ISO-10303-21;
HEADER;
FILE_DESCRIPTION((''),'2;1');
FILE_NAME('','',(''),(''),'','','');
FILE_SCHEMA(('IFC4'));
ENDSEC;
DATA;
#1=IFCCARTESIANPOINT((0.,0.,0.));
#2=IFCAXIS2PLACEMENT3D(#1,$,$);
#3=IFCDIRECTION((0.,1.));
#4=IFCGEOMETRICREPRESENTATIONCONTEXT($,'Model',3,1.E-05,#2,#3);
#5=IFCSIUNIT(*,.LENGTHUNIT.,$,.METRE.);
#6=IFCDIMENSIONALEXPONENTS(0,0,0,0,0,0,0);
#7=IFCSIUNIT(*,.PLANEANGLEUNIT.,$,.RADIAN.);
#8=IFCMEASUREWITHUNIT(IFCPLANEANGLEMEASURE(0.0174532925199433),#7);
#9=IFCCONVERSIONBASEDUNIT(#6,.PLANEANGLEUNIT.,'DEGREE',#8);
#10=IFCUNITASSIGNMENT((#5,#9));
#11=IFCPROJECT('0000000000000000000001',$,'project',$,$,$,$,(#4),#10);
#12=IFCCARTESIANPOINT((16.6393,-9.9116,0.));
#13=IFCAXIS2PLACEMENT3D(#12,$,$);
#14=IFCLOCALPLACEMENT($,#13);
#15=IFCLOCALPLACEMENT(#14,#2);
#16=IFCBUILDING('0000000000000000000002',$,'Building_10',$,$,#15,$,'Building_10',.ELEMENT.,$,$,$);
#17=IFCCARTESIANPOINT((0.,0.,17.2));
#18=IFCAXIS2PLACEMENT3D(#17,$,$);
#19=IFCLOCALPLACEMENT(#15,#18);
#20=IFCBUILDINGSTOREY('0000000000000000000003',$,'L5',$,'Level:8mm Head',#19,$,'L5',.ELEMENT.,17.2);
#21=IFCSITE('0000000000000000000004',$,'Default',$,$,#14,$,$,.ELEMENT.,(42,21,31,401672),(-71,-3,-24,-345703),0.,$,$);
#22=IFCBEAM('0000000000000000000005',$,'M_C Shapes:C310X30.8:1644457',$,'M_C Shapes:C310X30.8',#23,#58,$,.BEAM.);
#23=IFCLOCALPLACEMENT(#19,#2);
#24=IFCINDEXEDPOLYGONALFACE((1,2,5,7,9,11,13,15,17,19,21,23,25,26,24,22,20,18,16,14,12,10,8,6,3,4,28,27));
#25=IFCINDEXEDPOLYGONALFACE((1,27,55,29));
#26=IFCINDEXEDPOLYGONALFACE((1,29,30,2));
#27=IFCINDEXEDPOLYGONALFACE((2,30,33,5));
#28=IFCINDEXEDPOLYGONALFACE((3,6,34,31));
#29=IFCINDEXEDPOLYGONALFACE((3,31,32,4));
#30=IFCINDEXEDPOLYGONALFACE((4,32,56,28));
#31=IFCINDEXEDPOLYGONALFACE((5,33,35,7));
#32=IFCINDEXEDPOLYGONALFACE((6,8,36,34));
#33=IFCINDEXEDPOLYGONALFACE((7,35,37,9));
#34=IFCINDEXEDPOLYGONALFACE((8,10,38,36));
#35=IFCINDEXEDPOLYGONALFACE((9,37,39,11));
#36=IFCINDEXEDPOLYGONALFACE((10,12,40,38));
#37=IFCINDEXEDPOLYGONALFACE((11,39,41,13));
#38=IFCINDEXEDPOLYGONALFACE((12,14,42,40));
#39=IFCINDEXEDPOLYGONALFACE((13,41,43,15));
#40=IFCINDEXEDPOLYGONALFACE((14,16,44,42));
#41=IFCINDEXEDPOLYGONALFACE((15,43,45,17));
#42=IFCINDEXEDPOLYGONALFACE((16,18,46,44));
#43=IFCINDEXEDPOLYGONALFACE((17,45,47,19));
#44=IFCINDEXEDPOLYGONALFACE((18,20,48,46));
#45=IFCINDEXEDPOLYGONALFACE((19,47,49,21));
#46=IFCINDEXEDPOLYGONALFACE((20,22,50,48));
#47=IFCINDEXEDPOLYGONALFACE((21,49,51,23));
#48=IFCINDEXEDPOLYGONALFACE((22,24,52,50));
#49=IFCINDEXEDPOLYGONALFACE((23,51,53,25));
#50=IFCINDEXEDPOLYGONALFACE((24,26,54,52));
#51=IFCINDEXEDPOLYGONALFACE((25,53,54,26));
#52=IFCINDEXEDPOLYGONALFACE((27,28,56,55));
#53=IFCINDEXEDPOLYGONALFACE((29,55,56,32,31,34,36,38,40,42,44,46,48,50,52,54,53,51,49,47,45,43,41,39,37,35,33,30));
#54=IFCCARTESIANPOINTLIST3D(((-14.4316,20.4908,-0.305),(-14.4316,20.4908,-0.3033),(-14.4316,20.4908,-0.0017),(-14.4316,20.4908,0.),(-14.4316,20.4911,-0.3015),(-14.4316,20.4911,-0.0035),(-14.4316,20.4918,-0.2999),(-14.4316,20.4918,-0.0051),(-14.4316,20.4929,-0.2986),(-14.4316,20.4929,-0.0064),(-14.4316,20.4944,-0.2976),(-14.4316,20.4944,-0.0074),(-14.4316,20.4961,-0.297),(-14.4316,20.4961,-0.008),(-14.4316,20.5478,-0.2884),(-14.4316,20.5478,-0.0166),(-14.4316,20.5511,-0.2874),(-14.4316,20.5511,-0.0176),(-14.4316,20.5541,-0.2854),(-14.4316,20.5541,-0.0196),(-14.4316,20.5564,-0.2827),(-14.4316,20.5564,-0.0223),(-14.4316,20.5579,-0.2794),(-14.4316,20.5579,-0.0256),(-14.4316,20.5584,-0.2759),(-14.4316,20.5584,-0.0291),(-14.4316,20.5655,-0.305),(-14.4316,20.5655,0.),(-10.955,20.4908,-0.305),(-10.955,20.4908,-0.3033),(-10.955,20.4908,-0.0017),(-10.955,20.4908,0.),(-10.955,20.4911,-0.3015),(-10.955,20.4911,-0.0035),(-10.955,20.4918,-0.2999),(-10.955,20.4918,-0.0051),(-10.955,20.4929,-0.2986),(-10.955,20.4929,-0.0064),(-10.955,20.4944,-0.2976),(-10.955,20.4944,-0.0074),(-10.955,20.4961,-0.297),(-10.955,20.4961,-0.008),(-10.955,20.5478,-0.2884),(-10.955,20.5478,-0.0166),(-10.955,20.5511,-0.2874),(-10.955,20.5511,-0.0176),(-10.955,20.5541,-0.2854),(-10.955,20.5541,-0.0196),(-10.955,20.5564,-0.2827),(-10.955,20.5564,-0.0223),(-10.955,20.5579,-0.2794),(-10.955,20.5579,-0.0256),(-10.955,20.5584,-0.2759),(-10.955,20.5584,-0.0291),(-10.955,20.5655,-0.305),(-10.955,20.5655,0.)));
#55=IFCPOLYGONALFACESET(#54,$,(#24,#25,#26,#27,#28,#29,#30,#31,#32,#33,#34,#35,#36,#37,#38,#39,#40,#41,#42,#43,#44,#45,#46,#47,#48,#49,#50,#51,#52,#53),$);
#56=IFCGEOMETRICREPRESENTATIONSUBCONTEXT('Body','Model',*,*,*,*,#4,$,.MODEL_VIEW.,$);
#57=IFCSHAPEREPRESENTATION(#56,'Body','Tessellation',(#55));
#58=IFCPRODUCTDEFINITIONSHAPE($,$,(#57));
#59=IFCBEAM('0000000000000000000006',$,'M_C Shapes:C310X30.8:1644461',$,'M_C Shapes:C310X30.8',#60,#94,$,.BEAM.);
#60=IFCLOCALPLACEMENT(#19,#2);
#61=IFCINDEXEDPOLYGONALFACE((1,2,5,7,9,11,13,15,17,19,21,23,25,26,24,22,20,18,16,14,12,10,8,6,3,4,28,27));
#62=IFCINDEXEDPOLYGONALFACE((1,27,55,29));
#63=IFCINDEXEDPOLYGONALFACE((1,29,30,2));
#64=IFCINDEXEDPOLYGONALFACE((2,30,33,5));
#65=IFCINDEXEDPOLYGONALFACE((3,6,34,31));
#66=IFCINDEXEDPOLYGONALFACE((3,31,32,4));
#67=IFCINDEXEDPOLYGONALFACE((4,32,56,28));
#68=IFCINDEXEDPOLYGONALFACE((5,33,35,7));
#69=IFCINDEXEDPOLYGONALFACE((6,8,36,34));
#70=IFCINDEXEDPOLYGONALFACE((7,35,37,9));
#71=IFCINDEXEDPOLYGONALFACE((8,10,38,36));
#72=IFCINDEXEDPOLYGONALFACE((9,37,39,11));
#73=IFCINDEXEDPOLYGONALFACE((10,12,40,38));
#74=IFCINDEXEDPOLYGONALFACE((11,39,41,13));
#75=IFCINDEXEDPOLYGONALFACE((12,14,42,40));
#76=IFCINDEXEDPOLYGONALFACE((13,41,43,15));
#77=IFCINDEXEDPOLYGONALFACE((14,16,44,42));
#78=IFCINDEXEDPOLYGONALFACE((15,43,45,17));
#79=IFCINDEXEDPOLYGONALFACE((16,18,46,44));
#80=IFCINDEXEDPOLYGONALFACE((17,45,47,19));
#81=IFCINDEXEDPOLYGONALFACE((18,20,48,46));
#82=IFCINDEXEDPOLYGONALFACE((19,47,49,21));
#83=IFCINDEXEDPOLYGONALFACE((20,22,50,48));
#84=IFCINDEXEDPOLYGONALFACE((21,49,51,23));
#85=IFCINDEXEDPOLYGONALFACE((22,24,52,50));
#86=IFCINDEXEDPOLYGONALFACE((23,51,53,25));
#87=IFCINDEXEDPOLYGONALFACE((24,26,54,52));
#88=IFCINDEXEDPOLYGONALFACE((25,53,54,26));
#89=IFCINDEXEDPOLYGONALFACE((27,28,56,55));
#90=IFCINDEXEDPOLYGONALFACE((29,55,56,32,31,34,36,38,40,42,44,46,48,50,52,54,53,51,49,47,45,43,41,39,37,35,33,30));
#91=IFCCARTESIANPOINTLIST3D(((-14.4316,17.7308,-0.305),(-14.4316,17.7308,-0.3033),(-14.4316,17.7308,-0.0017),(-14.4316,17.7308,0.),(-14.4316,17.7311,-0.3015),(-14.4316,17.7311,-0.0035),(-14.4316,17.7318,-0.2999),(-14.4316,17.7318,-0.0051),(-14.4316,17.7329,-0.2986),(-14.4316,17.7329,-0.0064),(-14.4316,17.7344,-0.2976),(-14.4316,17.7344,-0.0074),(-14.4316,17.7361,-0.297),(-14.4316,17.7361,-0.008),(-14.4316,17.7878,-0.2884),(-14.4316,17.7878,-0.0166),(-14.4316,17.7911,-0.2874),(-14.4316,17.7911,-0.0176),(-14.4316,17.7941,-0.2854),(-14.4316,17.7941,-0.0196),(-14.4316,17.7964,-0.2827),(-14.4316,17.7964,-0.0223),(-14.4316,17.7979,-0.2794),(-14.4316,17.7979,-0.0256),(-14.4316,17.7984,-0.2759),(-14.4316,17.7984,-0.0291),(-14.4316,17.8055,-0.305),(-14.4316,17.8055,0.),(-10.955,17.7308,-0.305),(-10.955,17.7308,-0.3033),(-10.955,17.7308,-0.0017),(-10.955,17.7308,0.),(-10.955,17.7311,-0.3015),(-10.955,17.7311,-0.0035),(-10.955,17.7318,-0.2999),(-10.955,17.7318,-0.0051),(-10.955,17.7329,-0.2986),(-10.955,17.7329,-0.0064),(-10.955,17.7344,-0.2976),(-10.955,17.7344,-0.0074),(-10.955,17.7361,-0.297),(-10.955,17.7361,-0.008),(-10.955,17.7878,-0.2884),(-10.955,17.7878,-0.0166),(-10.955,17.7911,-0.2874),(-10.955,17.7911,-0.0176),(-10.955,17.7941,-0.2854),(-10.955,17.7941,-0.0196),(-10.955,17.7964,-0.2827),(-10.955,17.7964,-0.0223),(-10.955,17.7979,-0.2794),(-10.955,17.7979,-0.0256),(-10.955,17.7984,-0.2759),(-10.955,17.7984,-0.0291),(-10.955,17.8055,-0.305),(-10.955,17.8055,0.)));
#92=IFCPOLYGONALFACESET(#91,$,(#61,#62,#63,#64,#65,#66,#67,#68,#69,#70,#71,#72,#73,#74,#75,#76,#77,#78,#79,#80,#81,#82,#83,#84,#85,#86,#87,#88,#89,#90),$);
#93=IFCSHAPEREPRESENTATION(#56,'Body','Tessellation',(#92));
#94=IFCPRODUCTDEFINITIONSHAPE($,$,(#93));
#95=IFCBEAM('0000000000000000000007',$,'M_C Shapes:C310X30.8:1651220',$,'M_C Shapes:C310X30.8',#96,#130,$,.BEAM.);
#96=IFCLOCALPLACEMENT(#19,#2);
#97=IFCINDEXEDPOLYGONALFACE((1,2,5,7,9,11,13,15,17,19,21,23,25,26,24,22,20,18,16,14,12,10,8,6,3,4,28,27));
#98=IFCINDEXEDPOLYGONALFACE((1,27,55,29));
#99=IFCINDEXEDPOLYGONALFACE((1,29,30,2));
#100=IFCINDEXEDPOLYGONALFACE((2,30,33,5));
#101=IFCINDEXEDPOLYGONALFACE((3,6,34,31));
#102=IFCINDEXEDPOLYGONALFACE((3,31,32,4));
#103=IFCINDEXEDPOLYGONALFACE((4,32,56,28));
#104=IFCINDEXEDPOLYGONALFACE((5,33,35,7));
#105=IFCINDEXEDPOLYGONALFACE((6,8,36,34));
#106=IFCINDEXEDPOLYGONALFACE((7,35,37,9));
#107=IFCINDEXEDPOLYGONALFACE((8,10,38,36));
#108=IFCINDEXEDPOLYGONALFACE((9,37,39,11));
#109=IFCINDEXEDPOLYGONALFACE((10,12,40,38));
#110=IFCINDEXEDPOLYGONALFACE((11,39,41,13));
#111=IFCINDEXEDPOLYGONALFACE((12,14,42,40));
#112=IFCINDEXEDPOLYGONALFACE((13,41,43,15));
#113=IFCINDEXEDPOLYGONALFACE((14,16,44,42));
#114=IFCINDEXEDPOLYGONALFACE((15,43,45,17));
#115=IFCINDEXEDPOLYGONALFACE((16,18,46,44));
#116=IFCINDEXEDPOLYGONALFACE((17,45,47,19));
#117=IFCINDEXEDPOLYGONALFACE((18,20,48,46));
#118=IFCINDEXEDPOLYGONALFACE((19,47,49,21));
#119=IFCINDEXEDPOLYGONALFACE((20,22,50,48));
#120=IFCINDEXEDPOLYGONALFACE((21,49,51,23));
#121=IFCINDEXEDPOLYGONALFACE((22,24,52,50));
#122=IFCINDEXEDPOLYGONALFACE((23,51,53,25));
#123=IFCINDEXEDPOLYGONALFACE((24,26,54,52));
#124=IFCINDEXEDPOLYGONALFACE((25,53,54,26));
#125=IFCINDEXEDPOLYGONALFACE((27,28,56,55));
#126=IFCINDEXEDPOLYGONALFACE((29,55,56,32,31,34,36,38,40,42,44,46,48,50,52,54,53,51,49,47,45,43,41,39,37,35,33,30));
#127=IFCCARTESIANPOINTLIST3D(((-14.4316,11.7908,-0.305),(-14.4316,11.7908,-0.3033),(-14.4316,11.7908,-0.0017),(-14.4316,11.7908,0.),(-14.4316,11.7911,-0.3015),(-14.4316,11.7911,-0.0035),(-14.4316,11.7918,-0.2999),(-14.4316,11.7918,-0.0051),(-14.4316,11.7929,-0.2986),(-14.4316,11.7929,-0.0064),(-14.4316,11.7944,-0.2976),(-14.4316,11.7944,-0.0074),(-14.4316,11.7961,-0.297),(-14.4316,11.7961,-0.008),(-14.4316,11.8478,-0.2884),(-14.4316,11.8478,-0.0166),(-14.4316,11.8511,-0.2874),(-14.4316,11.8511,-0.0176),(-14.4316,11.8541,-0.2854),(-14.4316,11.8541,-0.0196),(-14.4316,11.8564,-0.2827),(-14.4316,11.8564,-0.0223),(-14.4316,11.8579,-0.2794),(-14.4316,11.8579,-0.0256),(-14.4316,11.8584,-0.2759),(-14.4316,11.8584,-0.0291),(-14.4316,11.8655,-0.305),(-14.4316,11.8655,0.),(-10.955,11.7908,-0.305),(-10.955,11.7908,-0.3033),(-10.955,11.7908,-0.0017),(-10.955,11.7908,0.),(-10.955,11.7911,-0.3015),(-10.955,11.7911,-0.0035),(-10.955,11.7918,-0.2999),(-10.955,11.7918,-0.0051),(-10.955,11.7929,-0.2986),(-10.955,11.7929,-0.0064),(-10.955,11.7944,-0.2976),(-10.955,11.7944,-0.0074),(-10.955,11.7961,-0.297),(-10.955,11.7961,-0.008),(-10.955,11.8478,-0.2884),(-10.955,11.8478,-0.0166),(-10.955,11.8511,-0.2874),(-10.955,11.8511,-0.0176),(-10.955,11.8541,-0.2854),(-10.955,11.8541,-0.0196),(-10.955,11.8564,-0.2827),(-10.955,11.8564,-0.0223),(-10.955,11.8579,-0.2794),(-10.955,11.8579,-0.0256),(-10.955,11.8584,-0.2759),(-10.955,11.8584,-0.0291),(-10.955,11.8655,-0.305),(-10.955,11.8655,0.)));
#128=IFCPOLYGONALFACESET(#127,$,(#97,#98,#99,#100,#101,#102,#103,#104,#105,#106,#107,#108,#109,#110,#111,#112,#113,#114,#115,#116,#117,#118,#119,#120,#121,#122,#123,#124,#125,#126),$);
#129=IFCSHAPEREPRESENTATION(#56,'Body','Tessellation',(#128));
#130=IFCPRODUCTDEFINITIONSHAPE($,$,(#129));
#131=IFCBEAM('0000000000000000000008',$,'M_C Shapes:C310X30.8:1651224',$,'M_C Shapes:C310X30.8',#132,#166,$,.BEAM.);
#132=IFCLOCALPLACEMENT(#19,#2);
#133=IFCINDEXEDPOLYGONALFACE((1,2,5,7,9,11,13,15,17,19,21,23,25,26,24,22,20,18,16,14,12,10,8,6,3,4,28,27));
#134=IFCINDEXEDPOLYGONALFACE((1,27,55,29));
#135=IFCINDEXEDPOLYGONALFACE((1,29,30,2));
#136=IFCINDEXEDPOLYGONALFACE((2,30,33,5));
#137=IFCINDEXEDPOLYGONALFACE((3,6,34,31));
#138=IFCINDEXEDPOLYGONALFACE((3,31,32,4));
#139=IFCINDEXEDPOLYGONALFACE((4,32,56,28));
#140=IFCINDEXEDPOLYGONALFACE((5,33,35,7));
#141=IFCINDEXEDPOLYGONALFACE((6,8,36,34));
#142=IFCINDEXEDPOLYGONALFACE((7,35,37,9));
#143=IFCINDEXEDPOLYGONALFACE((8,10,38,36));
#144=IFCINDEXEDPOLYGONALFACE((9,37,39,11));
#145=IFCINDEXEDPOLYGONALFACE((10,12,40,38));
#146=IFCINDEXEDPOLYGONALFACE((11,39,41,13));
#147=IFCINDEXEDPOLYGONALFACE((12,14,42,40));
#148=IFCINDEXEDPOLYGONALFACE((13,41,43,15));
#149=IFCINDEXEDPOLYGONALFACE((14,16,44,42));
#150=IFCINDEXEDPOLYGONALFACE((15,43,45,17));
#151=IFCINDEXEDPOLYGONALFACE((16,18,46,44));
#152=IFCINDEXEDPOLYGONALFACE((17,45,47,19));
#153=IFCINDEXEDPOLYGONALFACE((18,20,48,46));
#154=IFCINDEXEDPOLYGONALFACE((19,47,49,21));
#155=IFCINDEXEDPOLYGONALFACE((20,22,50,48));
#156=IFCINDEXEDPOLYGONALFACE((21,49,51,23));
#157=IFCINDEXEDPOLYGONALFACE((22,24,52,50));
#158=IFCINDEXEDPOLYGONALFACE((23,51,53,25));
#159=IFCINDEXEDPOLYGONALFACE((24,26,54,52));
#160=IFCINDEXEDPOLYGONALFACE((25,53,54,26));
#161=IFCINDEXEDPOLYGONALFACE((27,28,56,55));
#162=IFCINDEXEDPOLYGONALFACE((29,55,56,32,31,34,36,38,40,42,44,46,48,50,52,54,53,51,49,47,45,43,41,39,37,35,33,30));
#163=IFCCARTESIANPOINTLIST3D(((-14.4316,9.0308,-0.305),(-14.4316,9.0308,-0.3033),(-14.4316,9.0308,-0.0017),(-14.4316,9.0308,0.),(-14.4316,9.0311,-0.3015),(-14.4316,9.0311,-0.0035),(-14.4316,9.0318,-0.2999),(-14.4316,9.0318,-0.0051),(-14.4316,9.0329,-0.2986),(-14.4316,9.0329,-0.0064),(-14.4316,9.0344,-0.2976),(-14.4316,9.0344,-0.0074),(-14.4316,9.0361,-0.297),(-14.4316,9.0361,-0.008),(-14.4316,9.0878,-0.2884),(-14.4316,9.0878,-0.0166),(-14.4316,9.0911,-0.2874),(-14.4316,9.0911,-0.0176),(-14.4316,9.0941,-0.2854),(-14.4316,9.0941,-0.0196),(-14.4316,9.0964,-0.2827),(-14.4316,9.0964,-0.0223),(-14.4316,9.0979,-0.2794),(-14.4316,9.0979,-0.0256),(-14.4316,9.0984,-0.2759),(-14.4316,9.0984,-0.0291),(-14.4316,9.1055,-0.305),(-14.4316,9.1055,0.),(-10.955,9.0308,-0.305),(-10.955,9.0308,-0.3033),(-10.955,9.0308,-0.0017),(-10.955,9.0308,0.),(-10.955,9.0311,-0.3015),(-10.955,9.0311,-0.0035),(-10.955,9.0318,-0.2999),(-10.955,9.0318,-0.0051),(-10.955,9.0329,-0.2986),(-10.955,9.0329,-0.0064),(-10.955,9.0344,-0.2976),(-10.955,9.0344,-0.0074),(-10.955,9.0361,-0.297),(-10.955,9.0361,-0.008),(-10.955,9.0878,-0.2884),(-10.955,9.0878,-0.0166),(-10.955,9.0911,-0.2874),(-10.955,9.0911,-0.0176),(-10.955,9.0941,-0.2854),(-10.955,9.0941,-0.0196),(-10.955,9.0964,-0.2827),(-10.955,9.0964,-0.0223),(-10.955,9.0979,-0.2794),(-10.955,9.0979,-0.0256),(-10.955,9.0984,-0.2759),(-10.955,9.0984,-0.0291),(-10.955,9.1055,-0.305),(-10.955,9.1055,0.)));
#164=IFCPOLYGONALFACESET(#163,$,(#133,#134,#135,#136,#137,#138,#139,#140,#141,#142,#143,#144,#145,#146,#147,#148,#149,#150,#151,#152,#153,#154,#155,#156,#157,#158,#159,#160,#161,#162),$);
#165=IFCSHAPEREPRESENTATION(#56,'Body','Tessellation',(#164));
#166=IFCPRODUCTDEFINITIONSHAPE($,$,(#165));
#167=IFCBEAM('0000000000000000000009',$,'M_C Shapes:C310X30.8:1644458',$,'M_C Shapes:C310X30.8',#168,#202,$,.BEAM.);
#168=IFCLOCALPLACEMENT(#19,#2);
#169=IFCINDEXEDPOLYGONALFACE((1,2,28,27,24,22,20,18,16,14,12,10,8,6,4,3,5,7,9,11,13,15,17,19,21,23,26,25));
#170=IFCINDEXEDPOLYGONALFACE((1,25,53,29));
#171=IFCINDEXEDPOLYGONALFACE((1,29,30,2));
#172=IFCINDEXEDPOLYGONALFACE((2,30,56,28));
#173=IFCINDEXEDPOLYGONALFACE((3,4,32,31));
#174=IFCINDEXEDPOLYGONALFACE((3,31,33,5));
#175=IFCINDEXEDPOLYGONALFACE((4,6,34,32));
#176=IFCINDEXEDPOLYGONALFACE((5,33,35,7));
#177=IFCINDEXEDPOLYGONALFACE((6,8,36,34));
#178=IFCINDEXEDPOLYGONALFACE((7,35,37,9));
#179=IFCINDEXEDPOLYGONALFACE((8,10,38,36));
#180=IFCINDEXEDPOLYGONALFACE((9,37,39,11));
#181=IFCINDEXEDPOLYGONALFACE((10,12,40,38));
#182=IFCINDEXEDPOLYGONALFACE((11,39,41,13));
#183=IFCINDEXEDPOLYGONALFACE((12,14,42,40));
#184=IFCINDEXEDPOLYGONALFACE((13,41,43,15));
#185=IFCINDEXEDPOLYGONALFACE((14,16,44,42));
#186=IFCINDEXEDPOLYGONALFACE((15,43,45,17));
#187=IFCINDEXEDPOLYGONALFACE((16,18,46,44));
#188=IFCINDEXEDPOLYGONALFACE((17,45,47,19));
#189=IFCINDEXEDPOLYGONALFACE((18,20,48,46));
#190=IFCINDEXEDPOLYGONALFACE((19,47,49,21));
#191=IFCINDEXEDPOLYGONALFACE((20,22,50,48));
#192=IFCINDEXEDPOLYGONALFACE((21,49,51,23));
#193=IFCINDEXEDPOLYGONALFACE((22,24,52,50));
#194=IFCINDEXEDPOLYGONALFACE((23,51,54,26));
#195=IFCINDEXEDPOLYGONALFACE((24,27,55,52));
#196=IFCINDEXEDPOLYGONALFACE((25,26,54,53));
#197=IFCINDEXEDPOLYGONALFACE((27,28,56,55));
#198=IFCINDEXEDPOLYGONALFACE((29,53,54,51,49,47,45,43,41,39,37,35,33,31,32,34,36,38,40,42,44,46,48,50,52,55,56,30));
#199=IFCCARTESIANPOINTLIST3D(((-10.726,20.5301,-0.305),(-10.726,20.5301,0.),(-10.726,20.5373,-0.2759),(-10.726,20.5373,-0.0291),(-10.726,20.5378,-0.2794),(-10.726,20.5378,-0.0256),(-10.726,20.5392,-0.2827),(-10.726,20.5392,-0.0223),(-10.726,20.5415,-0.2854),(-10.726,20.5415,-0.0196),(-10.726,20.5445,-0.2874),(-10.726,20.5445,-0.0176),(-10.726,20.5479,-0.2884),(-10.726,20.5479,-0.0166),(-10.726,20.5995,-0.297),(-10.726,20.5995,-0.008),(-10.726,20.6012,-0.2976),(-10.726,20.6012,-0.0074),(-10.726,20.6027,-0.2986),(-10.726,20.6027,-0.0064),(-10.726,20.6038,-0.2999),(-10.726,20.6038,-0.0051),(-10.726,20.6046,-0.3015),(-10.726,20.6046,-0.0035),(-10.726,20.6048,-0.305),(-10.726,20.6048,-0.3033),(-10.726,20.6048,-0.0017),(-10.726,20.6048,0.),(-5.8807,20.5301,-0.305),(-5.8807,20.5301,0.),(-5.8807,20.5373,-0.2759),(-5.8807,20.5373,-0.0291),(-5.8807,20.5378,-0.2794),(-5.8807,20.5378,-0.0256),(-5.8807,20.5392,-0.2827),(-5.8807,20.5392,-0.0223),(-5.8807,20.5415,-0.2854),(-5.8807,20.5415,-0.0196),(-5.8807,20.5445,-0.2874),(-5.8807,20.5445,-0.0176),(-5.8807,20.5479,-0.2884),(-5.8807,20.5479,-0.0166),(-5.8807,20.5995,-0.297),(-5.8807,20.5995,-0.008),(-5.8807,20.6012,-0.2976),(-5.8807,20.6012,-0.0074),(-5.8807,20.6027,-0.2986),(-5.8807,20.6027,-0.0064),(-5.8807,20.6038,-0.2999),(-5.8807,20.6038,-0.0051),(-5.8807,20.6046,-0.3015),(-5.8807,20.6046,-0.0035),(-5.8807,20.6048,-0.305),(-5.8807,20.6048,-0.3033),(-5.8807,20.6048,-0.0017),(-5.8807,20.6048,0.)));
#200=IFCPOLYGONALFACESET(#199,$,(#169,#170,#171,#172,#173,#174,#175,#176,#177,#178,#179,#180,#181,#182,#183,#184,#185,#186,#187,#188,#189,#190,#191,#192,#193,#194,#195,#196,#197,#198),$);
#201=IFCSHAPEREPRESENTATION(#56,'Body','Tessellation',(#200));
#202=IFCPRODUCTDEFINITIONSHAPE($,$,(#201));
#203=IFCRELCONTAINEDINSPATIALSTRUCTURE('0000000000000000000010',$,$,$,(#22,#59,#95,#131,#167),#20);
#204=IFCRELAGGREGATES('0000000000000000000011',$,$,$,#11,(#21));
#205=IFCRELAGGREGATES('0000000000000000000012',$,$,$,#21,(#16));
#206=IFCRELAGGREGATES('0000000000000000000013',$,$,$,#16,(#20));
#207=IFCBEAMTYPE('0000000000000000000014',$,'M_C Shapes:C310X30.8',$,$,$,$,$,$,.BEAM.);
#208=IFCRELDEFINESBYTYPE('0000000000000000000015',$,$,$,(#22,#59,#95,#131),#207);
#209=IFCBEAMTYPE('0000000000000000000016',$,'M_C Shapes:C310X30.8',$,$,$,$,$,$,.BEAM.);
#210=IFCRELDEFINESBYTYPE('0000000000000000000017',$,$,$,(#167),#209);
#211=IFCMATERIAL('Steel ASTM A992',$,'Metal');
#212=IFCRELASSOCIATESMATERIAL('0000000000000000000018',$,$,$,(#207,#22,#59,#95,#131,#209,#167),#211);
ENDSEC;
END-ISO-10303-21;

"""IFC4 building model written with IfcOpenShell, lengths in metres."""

from ifc_helpers import new_model, entity, si_unit, converted_unit, direction, frame, origin, place, context, subcontext, project, spatial, line, arc, indexed_curve, outline, extrude, source, transform, mapped, material, type_object, type_shapes, element, save


model = new_model("IFC4")

# Units and contexts
model_context = context("Model", 3, precision=1e-05, world=origin(), true_north=direction((0.0, 1.0)))
body_context = subcontext(model_context, "Body", "Model", "MODEL_VIEW")
ifc_project = project(units=[si_unit("LENGTHUNIT", "METRE"), converted_unit("PLANEANGLEUNIT", "DEGREE", entity("IfcPlaneAngleMeasure", 0.0174532925199433), si_unit("PLANEANGLEUNIT", "RADIAN"), dimensions=[0, 0, 0, 0, 0, 0, 0])], contexts=[model_context])

# Site, building, storey
site_placement = place(None, frame((16.6393, -9.9116, 0.0)))
site = spatial("IfcSite", under=ifc_project, at=site_placement, Name="Default", CompositionType="ELEMENT", RefLatitude=(42, 21, 31, 401672), RefLongitude=(-71, -3, -24, -345703), RefElevation=0.0)
building_placement = place(site_placement, origin())
building = spatial("IfcBuilding", under=site, at=building_placement, Name="Building_10", LongName="Building_10", CompositionType="ELEMENT")
storey_placement = place(building_placement, frame((0.0, 0.0, 17.2)))
storey = spatial("IfcBuildingStorey", under=building, at=storey_placement, Name="L5", ObjectType="Level:8mm Head", LongName="L5", CompositionType="ELEMENT", Elevation=17.2)

# Shared definitions
ifc_material = material(Name="Steel ASTM A992", Category="Metal")

# Beams
beam_type_1 = type_object("IfcBeamType", Name="M_C Shapes:C310X30.8", PredefinedType="BEAM", material=ifc_material)
shared_shape_1 = source(origin(), body_context, "Body", "SweptSolid", [
    extrude(outline(indexed_curve([(-0.0406, -0.1525), (0.0341, -0.1525), (0.0341, -0.1508), (0.0326, -0.1467), (0.0288, -0.1445), (-0.0228, -0.1359), (-0.0305, -0.1316), (-0.0335, -0.1234), (-0.0335, 0.1234), (-0.0305, 0.1316), (-0.0228, 0.1359), (0.0288, 0.1445), (0.0326, 0.1467), (0.0341, 0.1508), (0.0341, 0.1525), (-0.0406, 0.1525)], segments=[line(1, 2, 3), arc(3, 4, 5), line(5, 6), arc(6, 7, 8), line(8, 9), arc(9, 10, 11), line(11, 12), arc(12, 13, 14), line(14, 15, 16, 1)], self_intersect=False)), frame((-1.7383, -0.0229, 0.0), z_axis=(1.0, 0.0, 0.0), x_axis=(0.0, -1.0, 0.0)), (0.0, 0.0, 1.0), 3.4766),
])
type_shapes(beam_type_1, [shared_shape_1])
for number, where, name in (
    (1, (-12.6933, 20.5478, -0.1525), "M_C Shapes:C310X30.8:1644457"),
    (2, (-12.6933, 17.7878, -0.1525), "M_C Shapes:C310X30.8:1644461"),
    (3, (-12.6933, 11.8478, -0.1525), "M_C Shapes:C310X30.8:1651220"),
    (4, (-12.6933, 9.0878, -0.1525), "M_C Shapes:C310X30.8:1651224"),
):
    element("IfcBeam", number, at=place(storey_placement, frame(where)), inside=storey, type_object=beam_type_1, material=ifc_material, Name=name, ObjectType="M_C Shapes:C310X30.8", PredefinedType="BEAM", context=body_context, shape_type="MappedRepresentation", body=[
        mapped(shared_shape_1, transform((0.0, 0.0, 0.0), scale=1.0)),
    ])
beam_type_2 = type_object("IfcBeamType", Name="M_C Shapes:C310X30.8", PredefinedType="BEAM", material=ifc_material)
shared_shape_2 = source(origin(), body_context, "Body", "SweptSolid", [
    extrude(outline(indexed_curve([(-0.0406, -0.1525), (0.0341, -0.1525), (0.0341, -0.1508), (0.0326, -0.1467), (0.0288, -0.1445), (-0.0228, -0.1359), (-0.0305, -0.1316), (-0.0335, -0.1234), (-0.0335, 0.1234), (-0.0305, 0.1316), (-0.0228, 0.1359), (0.0288, 0.1445), (0.0326, 0.1467), (0.0341, 0.1508), (0.0341, 0.1525), (-0.0406, 0.1525)], segments=[line(1, 2, 3), arc(3, 4, 5), line(5, 6), arc(6, 7, 8), line(8, 9), arc(9, 10, 11), line(11, 12), arc(12, 13, 14), line(14, 15, 16, 1)], self_intersect=False)), frame((-2.4226, -0.0229, 0.0), z_axis=(1.0, 0.0, 0.0), x_axis=(0.0, -1.0, 0.0)), (0.0, 0.0, 1.0), 4.8453),
])
type_shapes(beam_type_2, [shared_shape_2])
beam_1_placement = place(storey_placement, frame((-8.3033, 20.5478, -0.1525), z_axis=(0.0, 0.0, 1.0), x_axis=(-1.0, 0.0, 0.0)))
element("IfcBeam", 5, at=beam_1_placement, inside=storey, type_object=beam_type_2, material=ifc_material, Name="M_C Shapes:C310X30.8:1644458", ObjectType="M_C Shapes:C310X30.8", PredefinedType="BEAM", context=body_context, shape_type="MappedRepresentation", body=[
    mapped(shared_shape_2, transform((0.0, 0.0, 0.0), scale=1.0)),
])

save(model, "model.ifc")
